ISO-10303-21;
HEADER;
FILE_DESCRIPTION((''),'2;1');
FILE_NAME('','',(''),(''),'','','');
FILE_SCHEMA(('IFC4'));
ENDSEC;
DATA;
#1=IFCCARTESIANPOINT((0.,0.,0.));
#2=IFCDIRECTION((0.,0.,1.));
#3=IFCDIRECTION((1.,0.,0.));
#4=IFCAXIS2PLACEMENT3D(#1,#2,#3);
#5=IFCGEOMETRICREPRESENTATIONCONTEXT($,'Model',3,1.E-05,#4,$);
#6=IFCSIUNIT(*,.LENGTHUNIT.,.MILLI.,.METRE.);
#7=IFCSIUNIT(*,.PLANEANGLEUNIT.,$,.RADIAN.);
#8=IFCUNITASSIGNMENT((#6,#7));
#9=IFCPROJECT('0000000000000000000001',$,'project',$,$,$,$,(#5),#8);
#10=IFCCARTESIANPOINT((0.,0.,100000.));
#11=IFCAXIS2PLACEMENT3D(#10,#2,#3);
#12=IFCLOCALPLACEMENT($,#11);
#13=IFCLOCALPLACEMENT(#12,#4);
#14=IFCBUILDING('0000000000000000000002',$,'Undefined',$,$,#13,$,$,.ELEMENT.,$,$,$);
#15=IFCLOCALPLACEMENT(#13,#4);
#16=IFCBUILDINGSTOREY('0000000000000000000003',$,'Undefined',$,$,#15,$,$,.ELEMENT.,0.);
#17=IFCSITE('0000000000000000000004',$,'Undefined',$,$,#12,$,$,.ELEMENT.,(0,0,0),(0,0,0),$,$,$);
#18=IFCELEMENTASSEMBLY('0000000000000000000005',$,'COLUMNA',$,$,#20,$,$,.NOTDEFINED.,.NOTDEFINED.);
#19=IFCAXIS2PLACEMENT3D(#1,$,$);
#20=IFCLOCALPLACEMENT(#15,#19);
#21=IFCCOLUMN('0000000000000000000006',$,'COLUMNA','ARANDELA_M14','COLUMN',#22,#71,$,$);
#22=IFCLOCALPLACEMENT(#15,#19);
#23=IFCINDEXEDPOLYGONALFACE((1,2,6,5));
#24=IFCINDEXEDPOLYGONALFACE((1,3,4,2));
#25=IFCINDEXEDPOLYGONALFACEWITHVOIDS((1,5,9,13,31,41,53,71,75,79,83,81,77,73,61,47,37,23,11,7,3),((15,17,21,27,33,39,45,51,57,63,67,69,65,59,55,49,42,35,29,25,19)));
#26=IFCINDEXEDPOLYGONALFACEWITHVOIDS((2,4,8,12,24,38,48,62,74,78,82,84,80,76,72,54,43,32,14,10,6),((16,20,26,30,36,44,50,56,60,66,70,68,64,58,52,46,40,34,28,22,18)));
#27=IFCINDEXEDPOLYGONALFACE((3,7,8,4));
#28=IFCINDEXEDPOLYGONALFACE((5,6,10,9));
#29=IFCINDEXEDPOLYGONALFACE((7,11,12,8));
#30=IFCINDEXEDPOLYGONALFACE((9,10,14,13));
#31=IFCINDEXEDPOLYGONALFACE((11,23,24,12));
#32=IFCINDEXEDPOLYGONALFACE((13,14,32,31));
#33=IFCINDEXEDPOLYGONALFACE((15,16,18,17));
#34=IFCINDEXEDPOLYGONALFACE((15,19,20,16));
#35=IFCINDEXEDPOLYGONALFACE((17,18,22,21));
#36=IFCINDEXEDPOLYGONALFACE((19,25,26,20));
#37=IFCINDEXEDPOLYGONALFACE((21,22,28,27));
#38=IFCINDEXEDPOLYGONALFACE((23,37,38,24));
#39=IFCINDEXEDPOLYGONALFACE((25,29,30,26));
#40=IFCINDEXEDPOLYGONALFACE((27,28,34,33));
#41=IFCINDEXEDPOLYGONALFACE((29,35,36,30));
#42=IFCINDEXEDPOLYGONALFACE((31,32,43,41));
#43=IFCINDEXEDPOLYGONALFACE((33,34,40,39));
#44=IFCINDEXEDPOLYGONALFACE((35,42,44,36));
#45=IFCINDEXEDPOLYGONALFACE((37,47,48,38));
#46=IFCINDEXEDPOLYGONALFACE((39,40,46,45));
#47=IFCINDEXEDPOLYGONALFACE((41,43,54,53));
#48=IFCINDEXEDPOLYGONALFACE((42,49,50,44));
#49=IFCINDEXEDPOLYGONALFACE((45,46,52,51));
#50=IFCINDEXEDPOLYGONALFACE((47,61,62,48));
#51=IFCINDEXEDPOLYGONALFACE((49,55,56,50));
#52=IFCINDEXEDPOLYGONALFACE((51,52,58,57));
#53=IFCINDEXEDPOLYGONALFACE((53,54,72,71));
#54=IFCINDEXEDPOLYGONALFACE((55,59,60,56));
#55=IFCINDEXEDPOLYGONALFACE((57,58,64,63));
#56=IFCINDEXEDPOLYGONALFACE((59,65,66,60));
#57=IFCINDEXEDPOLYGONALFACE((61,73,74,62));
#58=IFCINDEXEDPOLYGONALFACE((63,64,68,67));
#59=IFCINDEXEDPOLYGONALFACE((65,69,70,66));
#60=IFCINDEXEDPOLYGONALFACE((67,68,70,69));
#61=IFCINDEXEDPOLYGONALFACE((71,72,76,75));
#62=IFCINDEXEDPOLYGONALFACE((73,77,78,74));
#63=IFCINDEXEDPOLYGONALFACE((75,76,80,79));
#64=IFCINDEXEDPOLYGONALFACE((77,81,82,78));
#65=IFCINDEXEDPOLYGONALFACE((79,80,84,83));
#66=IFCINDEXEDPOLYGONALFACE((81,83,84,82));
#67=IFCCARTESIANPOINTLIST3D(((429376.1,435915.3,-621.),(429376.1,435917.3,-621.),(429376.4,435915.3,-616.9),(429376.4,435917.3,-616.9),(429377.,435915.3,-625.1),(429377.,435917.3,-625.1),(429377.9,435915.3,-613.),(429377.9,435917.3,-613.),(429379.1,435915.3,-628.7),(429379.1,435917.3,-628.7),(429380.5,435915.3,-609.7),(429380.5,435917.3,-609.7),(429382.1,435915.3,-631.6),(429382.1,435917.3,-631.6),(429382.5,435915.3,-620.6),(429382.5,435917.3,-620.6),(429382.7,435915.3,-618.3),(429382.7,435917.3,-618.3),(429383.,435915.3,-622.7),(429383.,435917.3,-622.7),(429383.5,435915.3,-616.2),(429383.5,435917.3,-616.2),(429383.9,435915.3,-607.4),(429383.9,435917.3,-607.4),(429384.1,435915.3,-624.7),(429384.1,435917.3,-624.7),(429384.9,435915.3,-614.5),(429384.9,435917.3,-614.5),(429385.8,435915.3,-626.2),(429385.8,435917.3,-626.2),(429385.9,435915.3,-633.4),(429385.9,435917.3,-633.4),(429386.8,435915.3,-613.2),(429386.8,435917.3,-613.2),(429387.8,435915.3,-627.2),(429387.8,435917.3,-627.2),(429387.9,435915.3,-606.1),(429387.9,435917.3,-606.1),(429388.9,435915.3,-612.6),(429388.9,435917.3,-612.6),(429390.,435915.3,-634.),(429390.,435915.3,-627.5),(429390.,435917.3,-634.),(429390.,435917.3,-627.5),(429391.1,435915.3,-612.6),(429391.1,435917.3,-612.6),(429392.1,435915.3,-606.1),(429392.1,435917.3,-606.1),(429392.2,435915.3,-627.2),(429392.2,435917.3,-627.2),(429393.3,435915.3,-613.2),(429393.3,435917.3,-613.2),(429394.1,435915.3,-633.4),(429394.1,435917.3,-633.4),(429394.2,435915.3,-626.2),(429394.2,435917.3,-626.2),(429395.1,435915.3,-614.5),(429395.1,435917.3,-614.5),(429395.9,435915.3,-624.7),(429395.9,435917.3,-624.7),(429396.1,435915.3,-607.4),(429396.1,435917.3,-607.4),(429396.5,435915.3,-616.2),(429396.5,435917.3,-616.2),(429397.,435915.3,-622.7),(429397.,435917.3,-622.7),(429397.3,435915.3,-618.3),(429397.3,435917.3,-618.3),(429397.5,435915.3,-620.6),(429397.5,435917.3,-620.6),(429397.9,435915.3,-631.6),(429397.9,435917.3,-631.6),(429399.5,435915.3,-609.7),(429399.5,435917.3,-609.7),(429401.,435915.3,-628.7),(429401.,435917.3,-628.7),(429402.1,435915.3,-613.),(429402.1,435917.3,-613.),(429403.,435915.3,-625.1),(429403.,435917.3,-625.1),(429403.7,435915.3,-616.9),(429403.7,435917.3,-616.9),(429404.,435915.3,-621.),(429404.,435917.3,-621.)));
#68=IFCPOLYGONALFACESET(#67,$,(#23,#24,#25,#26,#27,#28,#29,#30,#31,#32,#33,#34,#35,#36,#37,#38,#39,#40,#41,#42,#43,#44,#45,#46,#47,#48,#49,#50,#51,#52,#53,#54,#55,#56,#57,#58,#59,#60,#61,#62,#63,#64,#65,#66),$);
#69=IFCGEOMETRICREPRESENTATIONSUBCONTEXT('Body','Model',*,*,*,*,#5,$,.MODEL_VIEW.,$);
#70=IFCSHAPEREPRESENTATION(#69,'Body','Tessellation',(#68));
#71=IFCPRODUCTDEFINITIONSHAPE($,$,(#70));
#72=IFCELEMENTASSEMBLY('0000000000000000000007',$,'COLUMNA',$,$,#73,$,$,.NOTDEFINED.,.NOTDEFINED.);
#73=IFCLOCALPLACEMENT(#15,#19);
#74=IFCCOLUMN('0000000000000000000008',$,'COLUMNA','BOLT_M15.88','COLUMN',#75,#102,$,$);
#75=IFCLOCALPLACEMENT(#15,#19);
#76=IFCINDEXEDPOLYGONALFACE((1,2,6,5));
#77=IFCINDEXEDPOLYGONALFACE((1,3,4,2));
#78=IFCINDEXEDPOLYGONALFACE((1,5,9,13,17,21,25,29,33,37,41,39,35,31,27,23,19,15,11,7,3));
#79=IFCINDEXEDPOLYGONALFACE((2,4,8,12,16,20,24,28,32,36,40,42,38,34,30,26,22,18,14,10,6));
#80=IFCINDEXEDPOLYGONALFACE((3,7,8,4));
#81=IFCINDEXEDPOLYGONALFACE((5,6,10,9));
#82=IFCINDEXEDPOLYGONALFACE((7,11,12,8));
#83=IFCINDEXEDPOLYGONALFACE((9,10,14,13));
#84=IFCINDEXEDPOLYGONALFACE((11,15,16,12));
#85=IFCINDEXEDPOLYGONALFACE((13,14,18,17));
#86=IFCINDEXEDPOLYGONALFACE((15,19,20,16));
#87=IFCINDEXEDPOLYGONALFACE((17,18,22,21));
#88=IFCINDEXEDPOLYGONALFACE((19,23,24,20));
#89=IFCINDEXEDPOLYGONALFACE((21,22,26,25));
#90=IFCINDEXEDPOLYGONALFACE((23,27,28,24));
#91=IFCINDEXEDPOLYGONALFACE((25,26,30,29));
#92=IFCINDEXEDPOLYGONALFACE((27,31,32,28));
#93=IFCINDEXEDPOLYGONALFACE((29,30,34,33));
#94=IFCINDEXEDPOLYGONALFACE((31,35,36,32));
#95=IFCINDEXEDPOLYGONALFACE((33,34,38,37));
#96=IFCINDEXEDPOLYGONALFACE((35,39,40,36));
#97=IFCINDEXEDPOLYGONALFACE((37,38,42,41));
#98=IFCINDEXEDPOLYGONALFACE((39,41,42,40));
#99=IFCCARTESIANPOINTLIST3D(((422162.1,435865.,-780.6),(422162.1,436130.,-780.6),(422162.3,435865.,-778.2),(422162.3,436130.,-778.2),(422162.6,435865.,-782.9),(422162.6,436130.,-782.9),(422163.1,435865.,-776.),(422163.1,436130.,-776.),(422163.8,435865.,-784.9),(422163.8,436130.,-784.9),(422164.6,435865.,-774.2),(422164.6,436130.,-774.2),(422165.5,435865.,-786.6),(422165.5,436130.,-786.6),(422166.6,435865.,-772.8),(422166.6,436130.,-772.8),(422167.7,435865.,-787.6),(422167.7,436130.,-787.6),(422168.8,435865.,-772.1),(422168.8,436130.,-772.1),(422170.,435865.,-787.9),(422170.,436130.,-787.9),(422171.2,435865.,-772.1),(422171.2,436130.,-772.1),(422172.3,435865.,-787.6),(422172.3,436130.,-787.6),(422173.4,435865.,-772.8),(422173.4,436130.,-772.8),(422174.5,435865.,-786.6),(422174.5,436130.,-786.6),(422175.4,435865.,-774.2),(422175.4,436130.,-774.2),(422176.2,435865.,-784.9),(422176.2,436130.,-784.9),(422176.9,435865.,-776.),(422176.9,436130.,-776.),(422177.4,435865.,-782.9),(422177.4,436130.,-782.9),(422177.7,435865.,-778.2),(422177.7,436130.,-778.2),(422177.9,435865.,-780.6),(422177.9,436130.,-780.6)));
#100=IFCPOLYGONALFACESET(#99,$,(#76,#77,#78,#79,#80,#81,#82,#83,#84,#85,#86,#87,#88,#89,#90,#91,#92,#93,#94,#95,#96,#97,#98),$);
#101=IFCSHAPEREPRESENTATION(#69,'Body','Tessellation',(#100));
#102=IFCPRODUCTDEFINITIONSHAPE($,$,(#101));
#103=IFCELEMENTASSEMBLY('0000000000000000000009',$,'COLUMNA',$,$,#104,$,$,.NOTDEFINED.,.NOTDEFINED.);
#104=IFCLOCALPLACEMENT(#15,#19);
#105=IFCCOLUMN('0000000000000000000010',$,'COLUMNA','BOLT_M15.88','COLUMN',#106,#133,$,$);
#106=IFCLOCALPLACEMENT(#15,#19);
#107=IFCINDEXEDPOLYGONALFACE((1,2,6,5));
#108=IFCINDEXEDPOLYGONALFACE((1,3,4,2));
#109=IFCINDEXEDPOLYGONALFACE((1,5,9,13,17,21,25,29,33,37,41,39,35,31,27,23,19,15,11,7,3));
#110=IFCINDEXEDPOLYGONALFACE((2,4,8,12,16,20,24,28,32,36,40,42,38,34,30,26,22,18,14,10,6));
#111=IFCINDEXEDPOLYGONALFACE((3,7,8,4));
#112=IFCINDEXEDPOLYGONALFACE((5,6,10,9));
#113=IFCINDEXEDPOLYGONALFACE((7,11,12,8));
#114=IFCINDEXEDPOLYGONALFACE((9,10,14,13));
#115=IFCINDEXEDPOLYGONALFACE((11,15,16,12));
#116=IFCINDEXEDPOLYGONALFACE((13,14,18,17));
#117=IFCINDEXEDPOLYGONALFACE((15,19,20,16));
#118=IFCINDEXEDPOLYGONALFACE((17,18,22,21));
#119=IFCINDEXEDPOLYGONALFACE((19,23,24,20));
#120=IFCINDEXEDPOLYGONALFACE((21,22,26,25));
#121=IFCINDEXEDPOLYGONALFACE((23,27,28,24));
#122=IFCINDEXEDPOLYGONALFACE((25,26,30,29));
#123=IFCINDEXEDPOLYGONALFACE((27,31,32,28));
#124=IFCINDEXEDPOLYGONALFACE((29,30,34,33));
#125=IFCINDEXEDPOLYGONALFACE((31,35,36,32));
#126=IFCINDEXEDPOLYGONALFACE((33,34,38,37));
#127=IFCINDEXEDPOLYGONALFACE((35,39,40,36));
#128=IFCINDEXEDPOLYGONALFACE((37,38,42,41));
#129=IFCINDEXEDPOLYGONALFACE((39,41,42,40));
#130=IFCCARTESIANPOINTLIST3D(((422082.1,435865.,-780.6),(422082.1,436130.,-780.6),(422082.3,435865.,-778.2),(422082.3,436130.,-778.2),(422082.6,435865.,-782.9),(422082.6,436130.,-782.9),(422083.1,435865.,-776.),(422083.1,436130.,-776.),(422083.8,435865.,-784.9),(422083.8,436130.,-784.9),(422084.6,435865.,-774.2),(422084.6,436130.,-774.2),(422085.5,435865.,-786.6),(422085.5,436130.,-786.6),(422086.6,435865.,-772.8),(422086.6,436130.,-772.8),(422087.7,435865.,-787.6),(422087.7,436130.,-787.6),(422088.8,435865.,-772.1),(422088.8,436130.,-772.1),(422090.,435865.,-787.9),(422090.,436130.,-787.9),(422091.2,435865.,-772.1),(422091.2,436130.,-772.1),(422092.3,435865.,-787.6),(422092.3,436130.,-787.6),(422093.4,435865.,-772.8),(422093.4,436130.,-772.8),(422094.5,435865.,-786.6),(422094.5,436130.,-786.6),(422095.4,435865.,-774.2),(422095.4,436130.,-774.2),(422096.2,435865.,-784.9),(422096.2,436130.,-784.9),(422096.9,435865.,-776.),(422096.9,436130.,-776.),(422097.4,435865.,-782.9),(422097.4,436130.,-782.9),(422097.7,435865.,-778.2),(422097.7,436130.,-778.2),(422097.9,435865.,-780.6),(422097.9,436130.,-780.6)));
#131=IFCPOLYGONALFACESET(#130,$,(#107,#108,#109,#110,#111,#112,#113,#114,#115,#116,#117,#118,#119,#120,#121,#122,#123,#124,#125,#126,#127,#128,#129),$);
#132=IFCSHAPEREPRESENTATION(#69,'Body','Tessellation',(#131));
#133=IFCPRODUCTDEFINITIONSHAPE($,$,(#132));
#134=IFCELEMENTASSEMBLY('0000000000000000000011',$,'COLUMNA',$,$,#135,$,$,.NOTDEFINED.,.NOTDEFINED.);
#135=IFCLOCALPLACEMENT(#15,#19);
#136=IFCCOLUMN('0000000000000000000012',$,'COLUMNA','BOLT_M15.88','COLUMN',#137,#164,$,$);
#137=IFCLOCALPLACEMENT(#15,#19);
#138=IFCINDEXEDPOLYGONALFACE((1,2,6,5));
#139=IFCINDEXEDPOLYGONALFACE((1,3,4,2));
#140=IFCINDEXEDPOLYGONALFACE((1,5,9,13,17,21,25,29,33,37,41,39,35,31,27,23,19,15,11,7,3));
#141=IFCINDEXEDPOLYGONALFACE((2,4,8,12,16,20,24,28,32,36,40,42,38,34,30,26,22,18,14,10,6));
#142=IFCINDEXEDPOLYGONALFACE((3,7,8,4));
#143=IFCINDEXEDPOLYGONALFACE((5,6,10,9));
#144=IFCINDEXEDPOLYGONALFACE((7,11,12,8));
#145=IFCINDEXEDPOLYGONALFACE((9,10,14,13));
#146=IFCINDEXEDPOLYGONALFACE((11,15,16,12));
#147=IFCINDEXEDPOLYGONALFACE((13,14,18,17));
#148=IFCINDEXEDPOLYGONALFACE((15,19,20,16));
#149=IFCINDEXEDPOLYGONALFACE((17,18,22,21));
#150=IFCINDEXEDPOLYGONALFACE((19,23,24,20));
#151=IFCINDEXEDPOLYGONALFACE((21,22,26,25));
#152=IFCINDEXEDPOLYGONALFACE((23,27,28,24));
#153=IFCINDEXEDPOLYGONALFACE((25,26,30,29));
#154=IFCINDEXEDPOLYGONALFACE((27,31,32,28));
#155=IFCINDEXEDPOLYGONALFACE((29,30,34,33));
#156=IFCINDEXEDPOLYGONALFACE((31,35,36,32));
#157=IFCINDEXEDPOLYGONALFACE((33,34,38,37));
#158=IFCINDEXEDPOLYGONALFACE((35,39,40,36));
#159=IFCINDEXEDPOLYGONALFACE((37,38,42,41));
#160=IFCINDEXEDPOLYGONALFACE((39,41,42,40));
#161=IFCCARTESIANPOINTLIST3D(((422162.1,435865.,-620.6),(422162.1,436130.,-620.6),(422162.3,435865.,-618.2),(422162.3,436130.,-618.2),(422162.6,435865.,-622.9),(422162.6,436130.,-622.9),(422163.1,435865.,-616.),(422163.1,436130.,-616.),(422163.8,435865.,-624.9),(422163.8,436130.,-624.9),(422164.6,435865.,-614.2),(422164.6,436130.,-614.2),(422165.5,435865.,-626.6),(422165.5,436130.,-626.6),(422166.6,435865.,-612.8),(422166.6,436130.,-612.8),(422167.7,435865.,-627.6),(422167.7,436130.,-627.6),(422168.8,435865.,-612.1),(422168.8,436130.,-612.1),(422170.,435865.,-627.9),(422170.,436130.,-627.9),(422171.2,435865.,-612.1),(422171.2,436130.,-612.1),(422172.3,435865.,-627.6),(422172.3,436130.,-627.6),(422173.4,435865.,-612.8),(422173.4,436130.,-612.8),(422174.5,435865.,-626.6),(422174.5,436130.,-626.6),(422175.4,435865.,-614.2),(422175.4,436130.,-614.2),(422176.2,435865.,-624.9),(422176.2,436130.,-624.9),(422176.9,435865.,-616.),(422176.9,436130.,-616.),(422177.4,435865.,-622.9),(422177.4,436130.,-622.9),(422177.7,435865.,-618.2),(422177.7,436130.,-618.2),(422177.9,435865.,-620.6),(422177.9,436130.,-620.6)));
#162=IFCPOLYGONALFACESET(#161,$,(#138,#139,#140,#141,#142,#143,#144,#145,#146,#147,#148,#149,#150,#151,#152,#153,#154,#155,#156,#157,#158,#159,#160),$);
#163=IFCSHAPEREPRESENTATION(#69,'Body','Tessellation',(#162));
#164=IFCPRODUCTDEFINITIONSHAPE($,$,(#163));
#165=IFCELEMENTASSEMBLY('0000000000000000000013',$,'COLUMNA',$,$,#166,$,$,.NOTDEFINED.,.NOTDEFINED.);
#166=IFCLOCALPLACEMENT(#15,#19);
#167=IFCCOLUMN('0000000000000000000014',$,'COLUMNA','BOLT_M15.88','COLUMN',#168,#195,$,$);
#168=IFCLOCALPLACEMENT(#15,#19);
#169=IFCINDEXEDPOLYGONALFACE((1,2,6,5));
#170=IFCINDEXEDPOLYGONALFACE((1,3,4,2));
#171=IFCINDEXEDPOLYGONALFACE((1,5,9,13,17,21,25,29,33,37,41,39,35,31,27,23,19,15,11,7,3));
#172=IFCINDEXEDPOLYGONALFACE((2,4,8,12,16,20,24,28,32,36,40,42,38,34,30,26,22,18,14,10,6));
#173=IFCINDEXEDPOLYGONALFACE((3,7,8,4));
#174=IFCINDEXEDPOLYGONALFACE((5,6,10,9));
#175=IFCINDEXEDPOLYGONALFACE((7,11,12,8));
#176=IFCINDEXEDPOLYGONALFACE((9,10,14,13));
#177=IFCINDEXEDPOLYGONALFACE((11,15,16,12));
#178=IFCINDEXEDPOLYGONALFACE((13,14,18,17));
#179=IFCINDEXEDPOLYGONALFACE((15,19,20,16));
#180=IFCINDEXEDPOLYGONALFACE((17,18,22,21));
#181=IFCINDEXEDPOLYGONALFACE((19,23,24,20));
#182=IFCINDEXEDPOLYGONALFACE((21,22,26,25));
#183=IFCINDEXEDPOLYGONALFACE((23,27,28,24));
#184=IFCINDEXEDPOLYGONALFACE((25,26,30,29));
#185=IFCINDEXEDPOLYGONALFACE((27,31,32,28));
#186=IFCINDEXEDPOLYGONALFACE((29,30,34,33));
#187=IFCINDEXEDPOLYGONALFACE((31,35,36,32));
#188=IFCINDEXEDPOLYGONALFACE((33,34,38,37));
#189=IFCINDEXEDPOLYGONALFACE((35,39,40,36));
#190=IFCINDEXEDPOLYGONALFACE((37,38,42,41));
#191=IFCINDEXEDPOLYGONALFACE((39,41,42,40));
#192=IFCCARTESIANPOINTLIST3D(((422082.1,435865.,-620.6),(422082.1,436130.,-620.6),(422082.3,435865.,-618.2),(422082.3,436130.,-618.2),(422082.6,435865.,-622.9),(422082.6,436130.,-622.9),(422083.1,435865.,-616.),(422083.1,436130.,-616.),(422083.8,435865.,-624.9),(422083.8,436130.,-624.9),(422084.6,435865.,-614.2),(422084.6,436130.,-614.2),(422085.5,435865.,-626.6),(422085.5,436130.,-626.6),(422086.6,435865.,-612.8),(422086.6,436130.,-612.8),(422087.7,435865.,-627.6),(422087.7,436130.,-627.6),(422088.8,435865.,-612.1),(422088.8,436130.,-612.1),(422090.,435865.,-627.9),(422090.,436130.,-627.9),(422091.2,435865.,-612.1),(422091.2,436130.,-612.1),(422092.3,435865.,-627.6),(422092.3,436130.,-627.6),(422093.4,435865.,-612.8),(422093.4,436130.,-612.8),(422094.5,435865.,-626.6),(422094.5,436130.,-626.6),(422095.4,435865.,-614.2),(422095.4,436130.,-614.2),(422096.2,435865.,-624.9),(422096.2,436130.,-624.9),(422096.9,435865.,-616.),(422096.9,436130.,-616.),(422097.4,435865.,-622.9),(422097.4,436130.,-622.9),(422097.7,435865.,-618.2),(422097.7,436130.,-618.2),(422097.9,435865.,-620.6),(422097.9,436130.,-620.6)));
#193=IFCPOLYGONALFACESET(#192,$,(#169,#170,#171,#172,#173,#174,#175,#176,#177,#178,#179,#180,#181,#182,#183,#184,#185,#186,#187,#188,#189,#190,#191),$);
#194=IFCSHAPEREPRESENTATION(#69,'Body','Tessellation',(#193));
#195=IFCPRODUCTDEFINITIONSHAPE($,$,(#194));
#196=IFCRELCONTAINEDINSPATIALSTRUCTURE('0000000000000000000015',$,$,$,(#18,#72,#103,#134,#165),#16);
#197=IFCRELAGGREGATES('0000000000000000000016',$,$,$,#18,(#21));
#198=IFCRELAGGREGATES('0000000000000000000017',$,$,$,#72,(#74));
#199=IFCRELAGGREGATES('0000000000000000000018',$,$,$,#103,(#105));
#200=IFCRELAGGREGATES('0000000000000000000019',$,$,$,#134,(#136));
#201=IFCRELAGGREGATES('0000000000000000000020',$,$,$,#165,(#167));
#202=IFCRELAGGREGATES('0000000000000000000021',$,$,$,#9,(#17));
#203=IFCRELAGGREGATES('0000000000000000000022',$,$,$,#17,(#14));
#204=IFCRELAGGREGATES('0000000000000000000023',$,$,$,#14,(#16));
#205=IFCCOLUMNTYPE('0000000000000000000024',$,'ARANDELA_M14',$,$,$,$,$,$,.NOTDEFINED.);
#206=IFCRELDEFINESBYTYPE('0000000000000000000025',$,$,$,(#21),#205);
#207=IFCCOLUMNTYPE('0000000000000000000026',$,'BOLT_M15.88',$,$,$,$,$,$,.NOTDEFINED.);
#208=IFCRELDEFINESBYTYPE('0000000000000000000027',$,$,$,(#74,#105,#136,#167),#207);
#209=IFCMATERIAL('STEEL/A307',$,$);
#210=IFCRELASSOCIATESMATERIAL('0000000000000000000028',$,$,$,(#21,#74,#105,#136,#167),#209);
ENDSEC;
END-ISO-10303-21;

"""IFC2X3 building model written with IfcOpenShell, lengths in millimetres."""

from ifc_helpers import new_model, si_unit, frame, origin_with_axes, origin_2d_with_axis, place, context, subcontext, project, spatial, circle, hollow_circle, extrude, material, type_object, element, aggregate, save


model = new_model("IFC2X3")

# Units and contexts
model_context = context("Model", 3, precision=1e-05, world=origin_with_axes())
body_context = subcontext(model_context, "Body", "Model", "MODEL_VIEW")
ifc_project = project(units=[si_unit("LENGTHUNIT", "METRE", prefix="MILLI"), si_unit("PLANEANGLEUNIT", "RADIAN")], contexts=[model_context])

# Site, building, storey
site_placement = place(None, frame((0.0, 0.0, 100000.0), z_axis=(0.0, 0.0, 1.0), x_axis=(1.0, 0.0, 0.0)))
site = spatial("IfcSite", under=ifc_project, at=site_placement, Name="Undefined", CompositionType="ELEMENT", RefLatitude=(0, 0, 0), RefLongitude=(0, 0, 0))
building_placement = place(site_placement, origin_with_axes())
building = spatial("IfcBuilding", under=site, at=building_placement, Name="Undefined", CompositionType="ELEMENT")
storey_placement = place(building_placement, origin_with_axes())
storey = spatial("IfcBuildingStorey", under=building, at=storey_placement, Name="Undefined", CompositionType="ELEMENT", Elevation=0.0)

# Element assemblies, columns
assembly_1_placement = place(storey_placement, origin_with_axes())
assembly_1 = element("IfcElementAssembly", 1, at=assembly_1_placement, inside=storey, Name="COLUMNA", AssemblyPlace="NOTDEFINED", PredefinedType="NOTDEFINED")
ifc_material_1 = material(Name="STEEL/A307")
column_type_1 = type_object("IfcColumnType", Name="ARANDELA_M14", PredefinedType="NOTDEFINED")
column_1_placement = place(assembly_1_placement, frame((429390.0, 435917.3, -620.0), z_axis=(0.0, -1.0, 0.000285), x_axis=(-1.0, 0.0, 0.0)))
column_1 = element("IfcColumn", 2, at=column_1_placement, type_object=column_type_1, material=ifc_material_1, Name="COLUMNA", Description="ARANDELA_M14", ObjectType="COLUMN", context=body_context, shape_type="SweptSolid", body=[
    extrude(hollow_circle(Radius=14.0, WallThickness=6.5, at=origin_2d_with_axis()), frame((0.0, 0.0, 2.0), z_axis=(0.0, 0.0, -1.0), x_axis=(0.0, 1.0, 0.0)), (0.0, 0.0, 1.0), 2.0),
])
aggregate(assembly_1, [column_1])
assembly_2_placement = place(storey_placement, origin_with_axes())
assembly_2 = element("IfcElementAssembly", 3, at=assembly_2_placement, inside=storey, Name="COLUMNA", AssemblyPlace="NOTDEFINED", PredefinedType="NOTDEFINED")
column_type_2 = type_object("IfcColumnType", Name="BOLT_M15.88", PredefinedType="NOTDEFINED")
column_2_placement = place(assembly_2_placement, frame((422170.0, 436130.0, -780.0), z_axis=(0.0, -1.0, -0.000003), x_axis=(-1.0, 0.0, 0.0)))
column_2 = element("IfcColumn", 4, at=column_2_placement, type_object=column_type_2, material=ifc_material_1, Name="COLUMNA", Description="BOLT_M15.88", ObjectType="COLUMN", context=body_context, shape_type="SweptSolid", body=[
    extrude(circle(Radius=7.9, at=origin_2d_with_axis()), frame((0.0, 0.0, 265.0), z_axis=(0.0, 0.0, -1.0), x_axis=(0.0, 1.0, 0.0)), (0.0, 0.0, 1.0), 265.0),
])
aggregate(assembly_2, [column_2])
assembly_3_placement = place(storey_placement, origin_with_axes())
assembly_3 = element("IfcElementAssembly", 5, at=assembly_3_placement, inside=storey, Name="COLUMNA", AssemblyPlace="NOTDEFINED", PredefinedType="NOTDEFINED")
column_3_placement = place(assembly_3_placement, frame((422090.0, 436130.0, -780.0), z_axis=(0.0, -1.0, -0.000003), x_axis=(-1.0, 0.0, 0.0)))
column_3 = element("IfcColumn", 6, at=column_3_placement, type_object=column_type_2, material=ifc_material_1, Name="COLUMNA", Description="BOLT_M15.88", ObjectType="COLUMN", context=body_context, shape_type="SweptSolid", body=[
    extrude(circle(Radius=7.9, at=origin_2d_with_axis()), frame((0.0, 0.0, 265.0), z_axis=(0.0, 0.0, -1.0), x_axis=(0.0, 1.0, 0.0)), (0.0, 0.0, 1.0), 265.0),
])
aggregate(assembly_3, [column_3])
assembly_4_placement = place(storey_placement, origin_with_axes())
assembly_4 = element("IfcElementAssembly", 7, at=assembly_4_placement, inside=storey, Name="COLUMNA", AssemblyPlace="NOTDEFINED", PredefinedType="NOTDEFINED")
column_4_placement = place(assembly_4_placement, frame((422170.0, 436130.0, -620.0), z_axis=(0.0, -1.0, -0.000003), x_axis=(-1.0, 0.0, 0.0)))
column_4 = element("IfcColumn", 8, at=column_4_placement, type_object=column_type_2, material=ifc_material_1, Name="COLUMNA", Description="BOLT_M15.88", ObjectType="COLUMN", context=body_context, shape_type="SweptSolid", body=[
    extrude(circle(Radius=7.9, at=origin_2d_with_axis()), frame((0.0, 0.0, 265.0), z_axis=(0.0, 0.0, -1.0), x_axis=(0.0, 1.0, 0.0)), (0.0, 0.0, 1.0), 265.0),
])
aggregate(assembly_4, [column_4])
assembly_5_placement = place(storey_placement, origin_with_axes())
assembly_5 = element("IfcElementAssembly", 9, at=assembly_5_placement, inside=storey, Name="COLUMNA", AssemblyPlace="NOTDEFINED", PredefinedType="NOTDEFINED")
column_5_placement = place(assembly_5_placement, frame((422090.0, 436130.0, -620.0), z_axis=(0.0, -1.0, -0.000003), x_axis=(-1.0, 0.0, 0.0)))
column_5 = element("IfcColumn", 10, at=column_5_placement, type_object=column_type_2, material=ifc_material_1, Name="COLUMNA", Description="BOLT_M15.88", ObjectType="COLUMN", context=body_context, shape_type="SweptSolid", body=[
    extrude(circle(Radius=7.9, at=origin_2d_with_axis()), frame((0.0, 0.0, 265.0), z_axis=(0.0, 0.0, -1.0), x_axis=(0.0, 1.0, 0.0)), (0.0, 0.0, 1.0), 265.0),
])
aggregate(assembly_5, [column_5])

save(model, "model.ifc")
